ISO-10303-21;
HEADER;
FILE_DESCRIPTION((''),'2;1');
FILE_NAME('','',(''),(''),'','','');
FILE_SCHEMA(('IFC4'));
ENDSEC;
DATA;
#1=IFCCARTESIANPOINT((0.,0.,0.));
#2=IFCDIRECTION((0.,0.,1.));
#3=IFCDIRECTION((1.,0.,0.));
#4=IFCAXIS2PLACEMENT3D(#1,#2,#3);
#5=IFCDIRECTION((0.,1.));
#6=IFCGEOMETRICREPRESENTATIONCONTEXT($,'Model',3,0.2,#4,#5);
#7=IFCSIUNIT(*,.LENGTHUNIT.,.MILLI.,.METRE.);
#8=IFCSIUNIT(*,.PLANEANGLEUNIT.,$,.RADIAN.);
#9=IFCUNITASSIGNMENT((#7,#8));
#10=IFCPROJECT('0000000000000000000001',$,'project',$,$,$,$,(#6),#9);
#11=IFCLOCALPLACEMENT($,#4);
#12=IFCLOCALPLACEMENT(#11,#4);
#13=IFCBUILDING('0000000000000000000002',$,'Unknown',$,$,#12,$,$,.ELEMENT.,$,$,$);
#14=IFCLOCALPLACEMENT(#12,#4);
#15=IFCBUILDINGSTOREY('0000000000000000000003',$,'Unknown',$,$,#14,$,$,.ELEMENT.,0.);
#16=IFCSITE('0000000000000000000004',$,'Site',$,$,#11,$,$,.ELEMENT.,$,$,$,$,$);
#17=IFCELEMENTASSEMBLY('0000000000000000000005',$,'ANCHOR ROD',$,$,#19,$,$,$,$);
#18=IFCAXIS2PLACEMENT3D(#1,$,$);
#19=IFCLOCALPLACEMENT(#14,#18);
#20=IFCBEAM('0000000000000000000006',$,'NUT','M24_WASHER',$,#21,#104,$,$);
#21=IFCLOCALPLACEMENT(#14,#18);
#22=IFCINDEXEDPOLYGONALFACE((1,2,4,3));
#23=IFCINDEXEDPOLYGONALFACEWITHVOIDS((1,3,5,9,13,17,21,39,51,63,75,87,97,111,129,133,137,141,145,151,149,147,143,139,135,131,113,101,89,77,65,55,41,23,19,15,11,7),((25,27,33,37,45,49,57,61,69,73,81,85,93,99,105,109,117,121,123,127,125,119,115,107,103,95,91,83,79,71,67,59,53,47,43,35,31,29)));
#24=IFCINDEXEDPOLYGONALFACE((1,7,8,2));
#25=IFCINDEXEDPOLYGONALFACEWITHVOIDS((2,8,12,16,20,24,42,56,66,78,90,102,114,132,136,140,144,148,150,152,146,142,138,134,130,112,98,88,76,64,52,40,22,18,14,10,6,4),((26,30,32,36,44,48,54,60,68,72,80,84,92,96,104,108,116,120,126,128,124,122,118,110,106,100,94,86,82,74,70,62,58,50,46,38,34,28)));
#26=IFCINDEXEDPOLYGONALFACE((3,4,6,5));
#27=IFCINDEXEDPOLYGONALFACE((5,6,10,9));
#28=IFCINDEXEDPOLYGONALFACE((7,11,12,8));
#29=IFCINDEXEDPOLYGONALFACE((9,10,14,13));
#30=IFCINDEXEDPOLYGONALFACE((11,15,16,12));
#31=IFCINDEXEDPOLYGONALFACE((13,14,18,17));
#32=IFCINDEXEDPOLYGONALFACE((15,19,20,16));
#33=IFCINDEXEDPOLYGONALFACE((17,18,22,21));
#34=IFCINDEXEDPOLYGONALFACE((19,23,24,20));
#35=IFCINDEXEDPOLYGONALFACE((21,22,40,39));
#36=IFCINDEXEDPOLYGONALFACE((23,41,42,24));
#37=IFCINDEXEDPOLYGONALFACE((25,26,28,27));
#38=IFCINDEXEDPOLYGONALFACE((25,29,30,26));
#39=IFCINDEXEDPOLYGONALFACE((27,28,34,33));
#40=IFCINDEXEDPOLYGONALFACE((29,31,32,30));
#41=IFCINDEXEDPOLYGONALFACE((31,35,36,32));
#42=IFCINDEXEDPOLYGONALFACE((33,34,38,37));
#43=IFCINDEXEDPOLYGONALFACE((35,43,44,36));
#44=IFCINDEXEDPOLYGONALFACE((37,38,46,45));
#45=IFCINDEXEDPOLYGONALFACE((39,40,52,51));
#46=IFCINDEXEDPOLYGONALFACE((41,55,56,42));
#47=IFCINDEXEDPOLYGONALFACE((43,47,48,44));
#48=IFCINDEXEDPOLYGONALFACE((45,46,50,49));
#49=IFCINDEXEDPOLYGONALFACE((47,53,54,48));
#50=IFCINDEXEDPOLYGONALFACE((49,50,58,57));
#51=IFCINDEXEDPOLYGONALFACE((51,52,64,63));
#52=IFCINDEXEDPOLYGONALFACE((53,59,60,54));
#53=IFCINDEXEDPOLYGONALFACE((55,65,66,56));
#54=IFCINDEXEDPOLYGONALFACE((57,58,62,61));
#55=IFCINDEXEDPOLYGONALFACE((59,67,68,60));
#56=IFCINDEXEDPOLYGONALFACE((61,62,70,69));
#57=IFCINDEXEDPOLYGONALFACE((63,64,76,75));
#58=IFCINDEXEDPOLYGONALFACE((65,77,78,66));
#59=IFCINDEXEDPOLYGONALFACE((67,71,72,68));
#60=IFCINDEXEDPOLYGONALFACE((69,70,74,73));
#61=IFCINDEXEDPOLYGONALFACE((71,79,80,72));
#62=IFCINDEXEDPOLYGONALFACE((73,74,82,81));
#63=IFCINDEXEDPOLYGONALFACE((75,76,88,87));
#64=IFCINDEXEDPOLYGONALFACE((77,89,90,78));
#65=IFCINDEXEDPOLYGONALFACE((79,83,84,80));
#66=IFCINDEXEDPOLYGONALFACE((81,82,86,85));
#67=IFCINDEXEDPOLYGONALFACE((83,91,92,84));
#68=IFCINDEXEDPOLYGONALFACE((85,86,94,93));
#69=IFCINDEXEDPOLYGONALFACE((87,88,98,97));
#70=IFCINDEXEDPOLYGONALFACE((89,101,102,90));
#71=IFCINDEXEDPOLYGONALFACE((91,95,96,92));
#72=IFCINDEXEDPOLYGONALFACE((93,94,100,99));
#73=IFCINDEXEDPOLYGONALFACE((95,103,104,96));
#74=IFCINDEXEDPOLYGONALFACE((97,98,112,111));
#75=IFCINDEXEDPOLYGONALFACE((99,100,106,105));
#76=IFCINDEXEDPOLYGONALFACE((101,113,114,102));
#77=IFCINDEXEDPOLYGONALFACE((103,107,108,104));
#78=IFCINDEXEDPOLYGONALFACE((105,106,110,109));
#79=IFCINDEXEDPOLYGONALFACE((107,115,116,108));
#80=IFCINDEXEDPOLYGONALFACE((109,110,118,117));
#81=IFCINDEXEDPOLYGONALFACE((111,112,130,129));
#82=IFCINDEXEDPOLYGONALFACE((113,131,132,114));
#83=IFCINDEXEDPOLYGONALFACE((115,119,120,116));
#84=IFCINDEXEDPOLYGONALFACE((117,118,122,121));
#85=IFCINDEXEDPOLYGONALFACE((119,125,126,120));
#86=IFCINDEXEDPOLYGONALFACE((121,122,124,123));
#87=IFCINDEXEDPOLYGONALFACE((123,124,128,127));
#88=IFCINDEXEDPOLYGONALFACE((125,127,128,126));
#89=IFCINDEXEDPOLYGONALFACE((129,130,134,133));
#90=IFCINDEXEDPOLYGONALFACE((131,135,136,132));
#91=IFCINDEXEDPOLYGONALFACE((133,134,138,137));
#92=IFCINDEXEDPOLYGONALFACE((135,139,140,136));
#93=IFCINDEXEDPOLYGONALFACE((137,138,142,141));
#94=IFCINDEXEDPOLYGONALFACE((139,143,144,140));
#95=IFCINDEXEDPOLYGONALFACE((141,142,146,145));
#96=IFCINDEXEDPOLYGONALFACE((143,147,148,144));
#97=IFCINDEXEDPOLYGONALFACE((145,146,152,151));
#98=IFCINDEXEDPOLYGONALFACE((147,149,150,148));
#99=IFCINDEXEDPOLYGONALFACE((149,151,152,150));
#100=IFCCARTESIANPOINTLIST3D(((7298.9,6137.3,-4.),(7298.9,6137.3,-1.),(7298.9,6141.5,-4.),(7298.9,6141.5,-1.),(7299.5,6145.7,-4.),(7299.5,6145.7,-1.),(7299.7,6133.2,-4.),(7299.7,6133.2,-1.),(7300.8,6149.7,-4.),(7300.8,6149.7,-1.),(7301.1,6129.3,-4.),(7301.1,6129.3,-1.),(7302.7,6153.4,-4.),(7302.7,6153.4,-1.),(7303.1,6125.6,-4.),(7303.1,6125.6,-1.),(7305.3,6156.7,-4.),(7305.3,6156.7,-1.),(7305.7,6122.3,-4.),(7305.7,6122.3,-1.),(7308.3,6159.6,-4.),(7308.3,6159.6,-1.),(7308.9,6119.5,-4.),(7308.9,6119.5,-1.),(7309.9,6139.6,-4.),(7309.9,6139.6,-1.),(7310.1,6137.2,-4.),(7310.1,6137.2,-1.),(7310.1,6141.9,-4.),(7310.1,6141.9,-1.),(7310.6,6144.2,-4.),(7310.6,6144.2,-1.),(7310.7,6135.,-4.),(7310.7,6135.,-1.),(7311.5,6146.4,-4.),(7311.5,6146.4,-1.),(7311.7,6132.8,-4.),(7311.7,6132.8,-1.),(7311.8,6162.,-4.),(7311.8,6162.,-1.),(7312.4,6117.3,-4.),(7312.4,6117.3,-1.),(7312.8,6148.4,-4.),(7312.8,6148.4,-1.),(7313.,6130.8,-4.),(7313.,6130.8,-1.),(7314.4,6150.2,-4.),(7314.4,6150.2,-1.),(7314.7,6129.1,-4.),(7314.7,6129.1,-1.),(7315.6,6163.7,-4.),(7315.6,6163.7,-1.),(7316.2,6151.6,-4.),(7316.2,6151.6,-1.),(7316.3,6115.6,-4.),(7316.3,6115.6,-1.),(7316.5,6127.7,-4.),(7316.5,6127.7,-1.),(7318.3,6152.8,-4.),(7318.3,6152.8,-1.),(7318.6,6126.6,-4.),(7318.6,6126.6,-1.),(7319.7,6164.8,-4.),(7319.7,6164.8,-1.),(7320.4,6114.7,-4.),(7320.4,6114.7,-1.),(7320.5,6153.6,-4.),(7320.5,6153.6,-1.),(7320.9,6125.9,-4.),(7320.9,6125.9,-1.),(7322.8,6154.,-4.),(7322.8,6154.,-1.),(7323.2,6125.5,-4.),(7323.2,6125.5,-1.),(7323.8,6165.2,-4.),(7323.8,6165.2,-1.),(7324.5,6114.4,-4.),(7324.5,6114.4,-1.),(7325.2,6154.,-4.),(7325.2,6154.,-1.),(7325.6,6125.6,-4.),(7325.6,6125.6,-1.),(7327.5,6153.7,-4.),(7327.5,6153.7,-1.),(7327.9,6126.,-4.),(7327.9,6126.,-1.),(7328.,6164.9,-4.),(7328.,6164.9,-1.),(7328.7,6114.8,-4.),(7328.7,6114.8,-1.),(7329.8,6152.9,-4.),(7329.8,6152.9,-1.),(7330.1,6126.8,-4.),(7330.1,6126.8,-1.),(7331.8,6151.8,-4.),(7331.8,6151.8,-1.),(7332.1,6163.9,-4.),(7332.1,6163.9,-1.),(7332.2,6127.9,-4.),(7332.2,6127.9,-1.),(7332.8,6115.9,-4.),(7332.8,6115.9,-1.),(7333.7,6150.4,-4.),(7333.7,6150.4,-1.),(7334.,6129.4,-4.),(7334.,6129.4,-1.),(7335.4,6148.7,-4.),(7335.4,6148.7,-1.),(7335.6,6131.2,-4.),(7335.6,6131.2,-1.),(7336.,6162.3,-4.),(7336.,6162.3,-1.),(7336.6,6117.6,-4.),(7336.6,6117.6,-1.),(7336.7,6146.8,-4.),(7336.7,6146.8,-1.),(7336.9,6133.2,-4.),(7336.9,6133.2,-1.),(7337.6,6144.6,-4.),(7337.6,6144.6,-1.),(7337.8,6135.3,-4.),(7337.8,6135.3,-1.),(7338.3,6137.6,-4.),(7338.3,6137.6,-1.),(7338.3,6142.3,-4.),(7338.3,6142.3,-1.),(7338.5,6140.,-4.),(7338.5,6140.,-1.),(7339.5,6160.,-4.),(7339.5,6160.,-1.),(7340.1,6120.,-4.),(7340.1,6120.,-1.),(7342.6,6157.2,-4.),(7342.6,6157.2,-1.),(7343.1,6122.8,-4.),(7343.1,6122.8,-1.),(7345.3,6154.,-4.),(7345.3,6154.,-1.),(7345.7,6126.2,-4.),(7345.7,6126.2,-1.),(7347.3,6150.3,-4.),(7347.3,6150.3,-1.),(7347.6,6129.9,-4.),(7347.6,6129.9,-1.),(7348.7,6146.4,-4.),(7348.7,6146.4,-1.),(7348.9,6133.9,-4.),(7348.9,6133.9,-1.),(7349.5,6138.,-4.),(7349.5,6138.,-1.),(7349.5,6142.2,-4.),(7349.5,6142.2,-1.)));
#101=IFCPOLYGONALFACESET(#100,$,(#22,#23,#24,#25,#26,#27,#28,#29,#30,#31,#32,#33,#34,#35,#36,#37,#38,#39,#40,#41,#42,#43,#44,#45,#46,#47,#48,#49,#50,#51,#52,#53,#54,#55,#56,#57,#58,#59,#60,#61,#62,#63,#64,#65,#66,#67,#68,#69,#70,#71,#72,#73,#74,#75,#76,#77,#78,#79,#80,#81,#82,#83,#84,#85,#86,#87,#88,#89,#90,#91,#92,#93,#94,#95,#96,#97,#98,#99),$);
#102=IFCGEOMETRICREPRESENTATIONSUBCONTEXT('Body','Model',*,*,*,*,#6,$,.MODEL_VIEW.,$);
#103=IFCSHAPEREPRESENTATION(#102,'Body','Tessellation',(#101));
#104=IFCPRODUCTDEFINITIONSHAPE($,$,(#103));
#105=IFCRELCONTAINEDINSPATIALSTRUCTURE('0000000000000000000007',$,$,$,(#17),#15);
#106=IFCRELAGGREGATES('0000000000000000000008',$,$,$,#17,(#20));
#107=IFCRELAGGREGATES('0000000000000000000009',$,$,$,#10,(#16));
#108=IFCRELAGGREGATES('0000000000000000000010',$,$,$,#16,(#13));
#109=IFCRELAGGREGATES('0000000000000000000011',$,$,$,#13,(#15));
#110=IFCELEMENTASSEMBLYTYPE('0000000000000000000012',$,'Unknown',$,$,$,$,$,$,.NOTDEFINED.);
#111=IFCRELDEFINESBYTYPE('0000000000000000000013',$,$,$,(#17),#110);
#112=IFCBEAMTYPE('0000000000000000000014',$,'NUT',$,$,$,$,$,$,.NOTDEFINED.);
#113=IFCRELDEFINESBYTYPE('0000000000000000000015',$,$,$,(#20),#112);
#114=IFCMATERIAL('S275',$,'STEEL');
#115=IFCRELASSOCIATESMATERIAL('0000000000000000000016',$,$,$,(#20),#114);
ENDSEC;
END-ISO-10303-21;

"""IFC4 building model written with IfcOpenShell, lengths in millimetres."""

from ifc_helpers import new_model, si_unit, direction, frame, origin_with_axes, place, context, subcontext, project, spatial, polyline, outline, extrude, material, material_profile, profile_set, profile_usage, type_object, element, aggregate, save


model = new_model("IFC4")

# Units and contexts
model_context = context("Model", 3, precision=0.2, world=origin_with_axes(), true_north=direction((0.0, 1.0)))
body_context = subcontext(model_context, "Body", "Model", "MODEL_VIEW")
ifc_project = project(units=[si_unit("LENGTHUNIT", "METRE", prefix="MILLI"), si_unit("PLANEANGLEUNIT", "RADIAN")], contexts=[model_context])

# Site, building, storey
site_placement = place(None, origin_with_axes())
site = spatial("IfcSite", under=ifc_project, at=site_placement, Name="Site", CompositionType="ELEMENT")
building_placement = place(site_placement, origin_with_axes())
building = spatial("IfcBuilding", under=site, at=building_placement, Name="Unknown", CompositionType="ELEMENT")
storey_placement = place(building_placement, origin_with_axes())
storey = spatial("IfcBuildingStorey", under=building, at=storey_placement, Name="Unknown", CompositionType="ELEMENT", Elevation=0.0)

# Element assembly, beam
element_assembly_type = type_object("IfcElementAssemblyType", Name="Unknown", PredefinedType="NOTDEFINED")
ifc_material_1 = material(Name="S275", Category="STEEL")
ifc_material_profile_1 = material_profile(ifc_material_1, outline(polyline([(25.4, 0.0), (25.1, 4.2), (24.0, 8.2), (22.3, 12.1), (20.0, 15.6), (17.2, 18.7), (13.9, 21.3), (10.2, 23.3), (6.2, 24.6), (2.1, 25.3), (-2.1, 25.3), (-6.2, 24.6), (-10.2, 23.3), (-13.9, 21.3), (-17.2, 18.7), (-20.0, 15.6), (-22.3, 12.1), (-24.0, 8.2), (-25.1, 4.2), (-25.4, 0.0), (-25.1, -4.2), (-24.0, -8.2), (-22.3, -12.1), (-20.0, -15.6), (-17.2, -18.7), (-13.9, -21.3), (-10.2, -23.3), (-6.2, -24.6), (-2.1, -25.3), (2.1, -25.3), (6.2, -24.6), (10.2, -23.3), (13.9, -21.3), (17.2, -18.7), (20.0, -15.6), (22.3, -12.1), (24.0, -8.2), (25.1, -4.2), (25.4, 0.0)]), holes=[polyline([(0.0, 14.3), (2.4, 14.1), (4.6, 13.5), (6.8, 12.6), (8.8, 11.3), (10.5, 9.7), (12.0, 7.8), (13.1, 5.7), (13.9, 3.5), (14.2, 1.2), (14.2, -1.2), (13.9, -3.5), (13.1, -5.7), (12.0, -7.8), (10.5, -9.7), (8.8, -11.3), (6.8, -12.6), (4.6, -13.5), (2.4, -14.1), (0.0, -14.3), (-2.4, -14.1), (-4.6, -13.5), (-6.8, -12.6), (-8.8, -11.3), (-10.5, -9.7), (-12.0, -7.8), (-13.1, -5.7), (-13.9, -3.5), (-14.2, -1.2), (-14.2, 1.2), (-13.9, 3.5), (-13.1, 5.7), (-12.0, 7.8), (-10.5, 9.7), (-8.8, 11.3), (-6.8, 12.6), (-4.6, 13.5), (-2.4, 14.1), (0.0, 14.3)])]), Name="M24_WASHER")
ifc_profile_set_1 = profile_set([ifc_material_profile_1])
ifc_profile_usage_1 = profile_usage(ifc_profile_set_1, cardinal=5)
beam_type_1 = type_object("IfcBeamType", Name="NUT", PredefinedType="NOTDEFINED")
assembly_1_placement = place(storey_placement, frame((7324.2, 6139.8, 39.0), z_axis=(0.154417, 0.988006, 0.0), x_axis=(0.0, 0.0, -1.0)))
assembly_1 = element("IfcElementAssembly", 1, at=assembly_1_placement, inside=storey, type_object=element_assembly_type, Name="ANCHOR ROD")
beam_1_placement = place(assembly_1_placement, frame((40.0, 0.0, 0.0), z_axis=(0.0, 0.003454, 0.999994), x_axis=(1.0, 0.0, 0.0)))
beam_1 = element("IfcBeam", 2, at=beam_1_placement, type_object=beam_type_1, material=ifc_profile_usage_1, Name="NUT", Description="M24_WASHER", context=body_context, shape_type="SolidModel", body=[
    extrude(outline(polyline([(25.4, 0.0), (25.1, 4.2), (24.0, 8.2), (22.3, 12.1), (20.0, 15.6), (17.2, 18.7), (13.9, 21.3), (10.2, 23.3), (6.2, 24.6), (2.1, 25.3), (-2.1, 25.3), (-6.2, 24.6), (-10.2, 23.3), (-13.9, 21.3), (-17.2, 18.7), (-20.0, 15.6), (-22.3, 12.1), (-24.0, 8.2), (-25.1, 4.2), (-25.4, 0.0), (-25.1, -4.2), (-24.0, -8.2), (-22.3, -12.1), (-20.0, -15.6), (-17.2, -18.7), (-13.9, -21.3), (-10.2, -23.3), (-6.2, -24.6), (-2.1, -25.3), (2.1, -25.3), (6.2, -24.6), (10.2, -23.3), (13.9, -21.3), (17.2, -18.7), (20.0, -15.6), (22.3, -12.1), (24.0, -8.2), (25.1, -4.2), (25.4, 0.0)]), holes=[polyline([(0.0, 14.3), (2.4, 14.1), (4.6, 13.5), (6.8, 12.6), (8.8, 11.3), (10.5, 9.7), (12.0, 7.8), (13.1, 5.7), (13.9, 3.5), (14.2, 1.2), (14.2, -1.2), (13.9, -3.5), (13.1, -5.7), (12.0, -7.8), (10.5, -9.7), (8.8, -11.3), (6.8, -12.6), (4.6, -13.5), (2.4, -14.1), (0.0, -14.3), (-2.4, -14.1), (-4.6, -13.5), (-6.8, -12.6), (-8.8, -11.3), (-10.5, -9.7), (-12.0, -7.8), (-13.1, -5.7), (-13.9, -3.5), (-14.2, -1.2), (-14.2, 1.2), (-13.9, 3.5), (-13.1, 5.7), (-12.0, 7.8), (-10.5, 9.7), (-8.8, 11.3), (-6.8, 12.6), (-4.6, 13.5), (-2.4, 14.1), (0.0, 14.3)])]), frame((0.0, 0.0, 0.0), z_axis=(-1.0, 0.0, 0.0), x_axis=(0.0, 0.0, 1.0)), (0.0, 0.0, -1.0), 3.0),
])

aggregate(assembly_1, [beam_1])

save(model, "model.ifc")
